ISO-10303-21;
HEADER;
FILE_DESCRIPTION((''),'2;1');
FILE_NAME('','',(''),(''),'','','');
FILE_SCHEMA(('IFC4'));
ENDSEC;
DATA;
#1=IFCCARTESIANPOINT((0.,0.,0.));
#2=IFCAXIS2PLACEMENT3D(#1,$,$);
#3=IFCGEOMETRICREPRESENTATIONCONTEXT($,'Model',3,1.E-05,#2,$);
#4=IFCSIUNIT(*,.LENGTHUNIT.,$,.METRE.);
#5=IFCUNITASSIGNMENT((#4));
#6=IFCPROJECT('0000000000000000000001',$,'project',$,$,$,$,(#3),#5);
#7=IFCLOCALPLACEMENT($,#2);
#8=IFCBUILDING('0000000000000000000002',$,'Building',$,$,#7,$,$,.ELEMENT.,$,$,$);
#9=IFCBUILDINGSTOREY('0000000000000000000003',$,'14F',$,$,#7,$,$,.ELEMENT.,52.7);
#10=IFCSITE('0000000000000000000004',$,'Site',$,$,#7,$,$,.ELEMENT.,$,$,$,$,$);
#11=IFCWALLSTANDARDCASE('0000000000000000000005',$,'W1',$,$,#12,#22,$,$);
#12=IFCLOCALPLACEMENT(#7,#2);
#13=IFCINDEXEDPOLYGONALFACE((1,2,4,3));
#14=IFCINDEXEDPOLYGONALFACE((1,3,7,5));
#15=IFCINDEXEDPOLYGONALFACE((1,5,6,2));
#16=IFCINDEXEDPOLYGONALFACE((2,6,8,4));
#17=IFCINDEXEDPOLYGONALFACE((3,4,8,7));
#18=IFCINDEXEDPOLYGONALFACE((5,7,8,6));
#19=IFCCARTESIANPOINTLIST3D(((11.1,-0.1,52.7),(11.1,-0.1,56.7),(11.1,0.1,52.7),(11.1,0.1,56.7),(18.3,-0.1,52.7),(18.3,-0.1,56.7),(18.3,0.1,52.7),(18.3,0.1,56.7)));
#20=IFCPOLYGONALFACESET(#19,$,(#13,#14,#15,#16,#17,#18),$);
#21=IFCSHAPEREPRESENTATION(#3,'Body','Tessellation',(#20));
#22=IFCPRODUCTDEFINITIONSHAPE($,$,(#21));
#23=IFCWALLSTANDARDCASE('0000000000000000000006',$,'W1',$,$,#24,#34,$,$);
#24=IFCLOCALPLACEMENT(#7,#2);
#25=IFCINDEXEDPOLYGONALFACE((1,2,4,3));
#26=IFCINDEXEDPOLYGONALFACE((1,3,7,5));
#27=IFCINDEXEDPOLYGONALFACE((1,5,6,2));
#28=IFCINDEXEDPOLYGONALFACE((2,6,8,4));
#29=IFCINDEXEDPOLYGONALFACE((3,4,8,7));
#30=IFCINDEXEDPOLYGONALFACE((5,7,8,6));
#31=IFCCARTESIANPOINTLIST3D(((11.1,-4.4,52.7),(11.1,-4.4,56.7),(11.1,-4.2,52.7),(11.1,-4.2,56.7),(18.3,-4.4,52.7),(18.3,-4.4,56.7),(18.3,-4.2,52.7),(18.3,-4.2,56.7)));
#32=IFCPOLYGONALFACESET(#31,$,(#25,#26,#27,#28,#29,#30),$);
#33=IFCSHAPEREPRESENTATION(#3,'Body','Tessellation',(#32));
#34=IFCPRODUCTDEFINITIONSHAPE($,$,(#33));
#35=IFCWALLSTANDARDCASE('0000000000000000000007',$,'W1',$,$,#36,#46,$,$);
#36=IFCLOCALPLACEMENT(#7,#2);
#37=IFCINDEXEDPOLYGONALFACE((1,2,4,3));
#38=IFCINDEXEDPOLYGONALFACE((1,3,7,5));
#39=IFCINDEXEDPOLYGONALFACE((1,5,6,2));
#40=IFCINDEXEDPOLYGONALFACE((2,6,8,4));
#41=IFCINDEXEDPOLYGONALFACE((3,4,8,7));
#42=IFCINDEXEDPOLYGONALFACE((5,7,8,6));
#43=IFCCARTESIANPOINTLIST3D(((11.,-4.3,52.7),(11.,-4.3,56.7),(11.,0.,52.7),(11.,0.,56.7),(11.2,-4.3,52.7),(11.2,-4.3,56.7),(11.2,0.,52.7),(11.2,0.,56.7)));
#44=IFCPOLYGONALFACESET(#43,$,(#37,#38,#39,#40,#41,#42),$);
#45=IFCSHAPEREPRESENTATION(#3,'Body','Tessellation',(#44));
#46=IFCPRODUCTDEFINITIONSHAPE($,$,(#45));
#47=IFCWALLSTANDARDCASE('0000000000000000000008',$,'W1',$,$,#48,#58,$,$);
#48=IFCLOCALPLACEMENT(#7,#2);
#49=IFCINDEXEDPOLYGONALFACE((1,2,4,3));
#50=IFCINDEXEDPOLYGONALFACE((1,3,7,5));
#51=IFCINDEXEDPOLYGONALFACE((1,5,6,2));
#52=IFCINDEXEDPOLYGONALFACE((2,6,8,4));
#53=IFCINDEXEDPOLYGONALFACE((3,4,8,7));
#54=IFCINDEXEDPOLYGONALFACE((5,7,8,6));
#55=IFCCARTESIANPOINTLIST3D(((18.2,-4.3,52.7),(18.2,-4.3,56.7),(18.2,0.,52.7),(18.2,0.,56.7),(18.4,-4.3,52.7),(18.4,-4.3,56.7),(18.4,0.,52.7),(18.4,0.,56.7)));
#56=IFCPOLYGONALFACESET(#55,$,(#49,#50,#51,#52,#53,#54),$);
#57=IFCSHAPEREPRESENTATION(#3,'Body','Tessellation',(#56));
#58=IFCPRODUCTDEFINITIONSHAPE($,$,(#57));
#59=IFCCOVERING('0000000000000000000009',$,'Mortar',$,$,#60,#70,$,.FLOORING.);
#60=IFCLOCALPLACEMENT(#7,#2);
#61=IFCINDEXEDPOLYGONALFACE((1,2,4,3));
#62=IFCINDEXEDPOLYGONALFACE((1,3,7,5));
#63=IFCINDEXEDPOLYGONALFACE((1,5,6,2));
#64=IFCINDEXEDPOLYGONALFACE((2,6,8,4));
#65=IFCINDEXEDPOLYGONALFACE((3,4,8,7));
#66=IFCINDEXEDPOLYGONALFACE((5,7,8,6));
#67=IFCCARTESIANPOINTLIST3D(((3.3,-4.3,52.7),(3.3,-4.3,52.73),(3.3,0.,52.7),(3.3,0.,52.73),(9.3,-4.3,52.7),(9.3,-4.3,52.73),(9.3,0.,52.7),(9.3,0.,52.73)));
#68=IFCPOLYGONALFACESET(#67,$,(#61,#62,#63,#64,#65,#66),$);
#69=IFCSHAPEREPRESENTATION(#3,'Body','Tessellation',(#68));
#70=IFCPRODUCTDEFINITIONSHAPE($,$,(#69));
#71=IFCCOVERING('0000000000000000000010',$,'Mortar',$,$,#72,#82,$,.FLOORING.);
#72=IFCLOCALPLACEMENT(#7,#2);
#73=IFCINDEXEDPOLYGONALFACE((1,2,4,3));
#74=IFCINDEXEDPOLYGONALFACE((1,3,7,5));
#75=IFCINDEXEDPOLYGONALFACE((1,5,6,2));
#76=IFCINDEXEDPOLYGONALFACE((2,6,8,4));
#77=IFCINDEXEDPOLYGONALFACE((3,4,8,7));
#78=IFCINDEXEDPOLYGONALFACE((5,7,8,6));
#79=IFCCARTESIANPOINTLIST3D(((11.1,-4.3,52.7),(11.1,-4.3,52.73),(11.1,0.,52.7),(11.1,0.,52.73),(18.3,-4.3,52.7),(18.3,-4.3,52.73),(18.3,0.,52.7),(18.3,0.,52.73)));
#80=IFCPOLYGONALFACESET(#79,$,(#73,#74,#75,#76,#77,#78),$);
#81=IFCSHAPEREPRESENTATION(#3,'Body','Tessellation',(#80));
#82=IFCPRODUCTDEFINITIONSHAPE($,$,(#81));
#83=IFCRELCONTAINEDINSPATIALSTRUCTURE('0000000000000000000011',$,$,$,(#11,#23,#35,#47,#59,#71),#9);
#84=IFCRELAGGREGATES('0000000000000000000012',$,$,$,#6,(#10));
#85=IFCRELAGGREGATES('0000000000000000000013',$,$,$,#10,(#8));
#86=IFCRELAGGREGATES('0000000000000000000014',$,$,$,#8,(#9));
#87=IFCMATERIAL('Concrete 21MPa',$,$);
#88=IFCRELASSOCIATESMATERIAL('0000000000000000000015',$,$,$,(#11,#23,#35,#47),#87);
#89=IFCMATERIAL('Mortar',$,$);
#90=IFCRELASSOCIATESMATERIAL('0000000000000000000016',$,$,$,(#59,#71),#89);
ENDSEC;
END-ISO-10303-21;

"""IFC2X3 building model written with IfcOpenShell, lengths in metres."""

from ifc_helpers import new_model, si_unit, frame, origin, origin_2d, place, context, project, spatial, rectangle, extrude, material, element, save


model = new_model("IFC2X3")

# Units and contexts
model_context = context("Model", 3, precision=1e-05, world=origin())
ifc_project = project(units=[si_unit("LENGTHUNIT", "METRE")], contexts=[model_context])

# Site, building, storey
placement = place(None, origin())
site = spatial("IfcSite", under=ifc_project, at=placement, Name="Site", CompositionType="ELEMENT")
building = spatial("IfcBuilding", under=site, at=placement, Name="Building", CompositionType="ELEMENT")
storey = spatial("IfcBuildingStorey", under=building, at=placement, Name="14F", CompositionType="ELEMENT", Elevation=52.7)

# Shared definitions
ifc_material_1 = material(Name="Concrete 21MPa")

# Walls
for number, where, name in (
    (1, (14.7, 0.0, 52.7), "W1"),
    (2, (14.7, -4.3, 52.7), "W1"),
):
    element("IfcWallStandardCase", number, at=place(None, frame(where)), inside=storey, material=ifc_material_1, Name=name, context=model_context, shape_type="SweptSolid", body=[
        extrude(rectangle(XDim=7.2, YDim=0.2, at=origin_2d()), origin(), (0.0, 0.0, 1.0), 4.0),
    ])
for number, where, name in (
    (3, (11.1, -2.15, 52.7), "W1"),
    (4, (18.3, -2.15, 52.7), "W1"),
):
    element("IfcWallStandardCase", number, at=place(None, frame(where)), inside=storey, material=ifc_material_1, Name=name, context=model_context, shape_type="SweptSolid", body=[
        extrude(rectangle(XDim=0.2, YDim=4.3, at=origin_2d()), origin(), (0.0, 0.0, 1.0), 4.0),
    ])

# Coverings
ifc_material_2 = material(Name="Mortar")
covering_1_placement = place(None, frame((6.3, -2.15, 52.7)))
element("IfcCovering", 5, at=covering_1_placement, inside=storey, material=ifc_material_2, Name="Mortar", PredefinedType="FLOORING", context=model_context, shape_type="SweptSolid", body=[
    extrude(rectangle(XDim=6.0, YDim=4.3, at=origin_2d()), origin(), (0.0, 0.0, 1.0), 0.03),
])
covering_2_placement = place(None, frame((14.7, -2.15, 52.7)))
element("IfcCovering", 6, at=covering_2_placement, inside=storey, material=ifc_material_2, Name="Mortar", PredefinedType="FLOORING", context=model_context, shape_type="SweptSolid", body=[
    extrude(rectangle(XDim=7.2, YDim=4.3, at=origin_2d()), origin(), (0.0, 0.0, 1.0), 0.03),
])

save(model, "model.ifc")
